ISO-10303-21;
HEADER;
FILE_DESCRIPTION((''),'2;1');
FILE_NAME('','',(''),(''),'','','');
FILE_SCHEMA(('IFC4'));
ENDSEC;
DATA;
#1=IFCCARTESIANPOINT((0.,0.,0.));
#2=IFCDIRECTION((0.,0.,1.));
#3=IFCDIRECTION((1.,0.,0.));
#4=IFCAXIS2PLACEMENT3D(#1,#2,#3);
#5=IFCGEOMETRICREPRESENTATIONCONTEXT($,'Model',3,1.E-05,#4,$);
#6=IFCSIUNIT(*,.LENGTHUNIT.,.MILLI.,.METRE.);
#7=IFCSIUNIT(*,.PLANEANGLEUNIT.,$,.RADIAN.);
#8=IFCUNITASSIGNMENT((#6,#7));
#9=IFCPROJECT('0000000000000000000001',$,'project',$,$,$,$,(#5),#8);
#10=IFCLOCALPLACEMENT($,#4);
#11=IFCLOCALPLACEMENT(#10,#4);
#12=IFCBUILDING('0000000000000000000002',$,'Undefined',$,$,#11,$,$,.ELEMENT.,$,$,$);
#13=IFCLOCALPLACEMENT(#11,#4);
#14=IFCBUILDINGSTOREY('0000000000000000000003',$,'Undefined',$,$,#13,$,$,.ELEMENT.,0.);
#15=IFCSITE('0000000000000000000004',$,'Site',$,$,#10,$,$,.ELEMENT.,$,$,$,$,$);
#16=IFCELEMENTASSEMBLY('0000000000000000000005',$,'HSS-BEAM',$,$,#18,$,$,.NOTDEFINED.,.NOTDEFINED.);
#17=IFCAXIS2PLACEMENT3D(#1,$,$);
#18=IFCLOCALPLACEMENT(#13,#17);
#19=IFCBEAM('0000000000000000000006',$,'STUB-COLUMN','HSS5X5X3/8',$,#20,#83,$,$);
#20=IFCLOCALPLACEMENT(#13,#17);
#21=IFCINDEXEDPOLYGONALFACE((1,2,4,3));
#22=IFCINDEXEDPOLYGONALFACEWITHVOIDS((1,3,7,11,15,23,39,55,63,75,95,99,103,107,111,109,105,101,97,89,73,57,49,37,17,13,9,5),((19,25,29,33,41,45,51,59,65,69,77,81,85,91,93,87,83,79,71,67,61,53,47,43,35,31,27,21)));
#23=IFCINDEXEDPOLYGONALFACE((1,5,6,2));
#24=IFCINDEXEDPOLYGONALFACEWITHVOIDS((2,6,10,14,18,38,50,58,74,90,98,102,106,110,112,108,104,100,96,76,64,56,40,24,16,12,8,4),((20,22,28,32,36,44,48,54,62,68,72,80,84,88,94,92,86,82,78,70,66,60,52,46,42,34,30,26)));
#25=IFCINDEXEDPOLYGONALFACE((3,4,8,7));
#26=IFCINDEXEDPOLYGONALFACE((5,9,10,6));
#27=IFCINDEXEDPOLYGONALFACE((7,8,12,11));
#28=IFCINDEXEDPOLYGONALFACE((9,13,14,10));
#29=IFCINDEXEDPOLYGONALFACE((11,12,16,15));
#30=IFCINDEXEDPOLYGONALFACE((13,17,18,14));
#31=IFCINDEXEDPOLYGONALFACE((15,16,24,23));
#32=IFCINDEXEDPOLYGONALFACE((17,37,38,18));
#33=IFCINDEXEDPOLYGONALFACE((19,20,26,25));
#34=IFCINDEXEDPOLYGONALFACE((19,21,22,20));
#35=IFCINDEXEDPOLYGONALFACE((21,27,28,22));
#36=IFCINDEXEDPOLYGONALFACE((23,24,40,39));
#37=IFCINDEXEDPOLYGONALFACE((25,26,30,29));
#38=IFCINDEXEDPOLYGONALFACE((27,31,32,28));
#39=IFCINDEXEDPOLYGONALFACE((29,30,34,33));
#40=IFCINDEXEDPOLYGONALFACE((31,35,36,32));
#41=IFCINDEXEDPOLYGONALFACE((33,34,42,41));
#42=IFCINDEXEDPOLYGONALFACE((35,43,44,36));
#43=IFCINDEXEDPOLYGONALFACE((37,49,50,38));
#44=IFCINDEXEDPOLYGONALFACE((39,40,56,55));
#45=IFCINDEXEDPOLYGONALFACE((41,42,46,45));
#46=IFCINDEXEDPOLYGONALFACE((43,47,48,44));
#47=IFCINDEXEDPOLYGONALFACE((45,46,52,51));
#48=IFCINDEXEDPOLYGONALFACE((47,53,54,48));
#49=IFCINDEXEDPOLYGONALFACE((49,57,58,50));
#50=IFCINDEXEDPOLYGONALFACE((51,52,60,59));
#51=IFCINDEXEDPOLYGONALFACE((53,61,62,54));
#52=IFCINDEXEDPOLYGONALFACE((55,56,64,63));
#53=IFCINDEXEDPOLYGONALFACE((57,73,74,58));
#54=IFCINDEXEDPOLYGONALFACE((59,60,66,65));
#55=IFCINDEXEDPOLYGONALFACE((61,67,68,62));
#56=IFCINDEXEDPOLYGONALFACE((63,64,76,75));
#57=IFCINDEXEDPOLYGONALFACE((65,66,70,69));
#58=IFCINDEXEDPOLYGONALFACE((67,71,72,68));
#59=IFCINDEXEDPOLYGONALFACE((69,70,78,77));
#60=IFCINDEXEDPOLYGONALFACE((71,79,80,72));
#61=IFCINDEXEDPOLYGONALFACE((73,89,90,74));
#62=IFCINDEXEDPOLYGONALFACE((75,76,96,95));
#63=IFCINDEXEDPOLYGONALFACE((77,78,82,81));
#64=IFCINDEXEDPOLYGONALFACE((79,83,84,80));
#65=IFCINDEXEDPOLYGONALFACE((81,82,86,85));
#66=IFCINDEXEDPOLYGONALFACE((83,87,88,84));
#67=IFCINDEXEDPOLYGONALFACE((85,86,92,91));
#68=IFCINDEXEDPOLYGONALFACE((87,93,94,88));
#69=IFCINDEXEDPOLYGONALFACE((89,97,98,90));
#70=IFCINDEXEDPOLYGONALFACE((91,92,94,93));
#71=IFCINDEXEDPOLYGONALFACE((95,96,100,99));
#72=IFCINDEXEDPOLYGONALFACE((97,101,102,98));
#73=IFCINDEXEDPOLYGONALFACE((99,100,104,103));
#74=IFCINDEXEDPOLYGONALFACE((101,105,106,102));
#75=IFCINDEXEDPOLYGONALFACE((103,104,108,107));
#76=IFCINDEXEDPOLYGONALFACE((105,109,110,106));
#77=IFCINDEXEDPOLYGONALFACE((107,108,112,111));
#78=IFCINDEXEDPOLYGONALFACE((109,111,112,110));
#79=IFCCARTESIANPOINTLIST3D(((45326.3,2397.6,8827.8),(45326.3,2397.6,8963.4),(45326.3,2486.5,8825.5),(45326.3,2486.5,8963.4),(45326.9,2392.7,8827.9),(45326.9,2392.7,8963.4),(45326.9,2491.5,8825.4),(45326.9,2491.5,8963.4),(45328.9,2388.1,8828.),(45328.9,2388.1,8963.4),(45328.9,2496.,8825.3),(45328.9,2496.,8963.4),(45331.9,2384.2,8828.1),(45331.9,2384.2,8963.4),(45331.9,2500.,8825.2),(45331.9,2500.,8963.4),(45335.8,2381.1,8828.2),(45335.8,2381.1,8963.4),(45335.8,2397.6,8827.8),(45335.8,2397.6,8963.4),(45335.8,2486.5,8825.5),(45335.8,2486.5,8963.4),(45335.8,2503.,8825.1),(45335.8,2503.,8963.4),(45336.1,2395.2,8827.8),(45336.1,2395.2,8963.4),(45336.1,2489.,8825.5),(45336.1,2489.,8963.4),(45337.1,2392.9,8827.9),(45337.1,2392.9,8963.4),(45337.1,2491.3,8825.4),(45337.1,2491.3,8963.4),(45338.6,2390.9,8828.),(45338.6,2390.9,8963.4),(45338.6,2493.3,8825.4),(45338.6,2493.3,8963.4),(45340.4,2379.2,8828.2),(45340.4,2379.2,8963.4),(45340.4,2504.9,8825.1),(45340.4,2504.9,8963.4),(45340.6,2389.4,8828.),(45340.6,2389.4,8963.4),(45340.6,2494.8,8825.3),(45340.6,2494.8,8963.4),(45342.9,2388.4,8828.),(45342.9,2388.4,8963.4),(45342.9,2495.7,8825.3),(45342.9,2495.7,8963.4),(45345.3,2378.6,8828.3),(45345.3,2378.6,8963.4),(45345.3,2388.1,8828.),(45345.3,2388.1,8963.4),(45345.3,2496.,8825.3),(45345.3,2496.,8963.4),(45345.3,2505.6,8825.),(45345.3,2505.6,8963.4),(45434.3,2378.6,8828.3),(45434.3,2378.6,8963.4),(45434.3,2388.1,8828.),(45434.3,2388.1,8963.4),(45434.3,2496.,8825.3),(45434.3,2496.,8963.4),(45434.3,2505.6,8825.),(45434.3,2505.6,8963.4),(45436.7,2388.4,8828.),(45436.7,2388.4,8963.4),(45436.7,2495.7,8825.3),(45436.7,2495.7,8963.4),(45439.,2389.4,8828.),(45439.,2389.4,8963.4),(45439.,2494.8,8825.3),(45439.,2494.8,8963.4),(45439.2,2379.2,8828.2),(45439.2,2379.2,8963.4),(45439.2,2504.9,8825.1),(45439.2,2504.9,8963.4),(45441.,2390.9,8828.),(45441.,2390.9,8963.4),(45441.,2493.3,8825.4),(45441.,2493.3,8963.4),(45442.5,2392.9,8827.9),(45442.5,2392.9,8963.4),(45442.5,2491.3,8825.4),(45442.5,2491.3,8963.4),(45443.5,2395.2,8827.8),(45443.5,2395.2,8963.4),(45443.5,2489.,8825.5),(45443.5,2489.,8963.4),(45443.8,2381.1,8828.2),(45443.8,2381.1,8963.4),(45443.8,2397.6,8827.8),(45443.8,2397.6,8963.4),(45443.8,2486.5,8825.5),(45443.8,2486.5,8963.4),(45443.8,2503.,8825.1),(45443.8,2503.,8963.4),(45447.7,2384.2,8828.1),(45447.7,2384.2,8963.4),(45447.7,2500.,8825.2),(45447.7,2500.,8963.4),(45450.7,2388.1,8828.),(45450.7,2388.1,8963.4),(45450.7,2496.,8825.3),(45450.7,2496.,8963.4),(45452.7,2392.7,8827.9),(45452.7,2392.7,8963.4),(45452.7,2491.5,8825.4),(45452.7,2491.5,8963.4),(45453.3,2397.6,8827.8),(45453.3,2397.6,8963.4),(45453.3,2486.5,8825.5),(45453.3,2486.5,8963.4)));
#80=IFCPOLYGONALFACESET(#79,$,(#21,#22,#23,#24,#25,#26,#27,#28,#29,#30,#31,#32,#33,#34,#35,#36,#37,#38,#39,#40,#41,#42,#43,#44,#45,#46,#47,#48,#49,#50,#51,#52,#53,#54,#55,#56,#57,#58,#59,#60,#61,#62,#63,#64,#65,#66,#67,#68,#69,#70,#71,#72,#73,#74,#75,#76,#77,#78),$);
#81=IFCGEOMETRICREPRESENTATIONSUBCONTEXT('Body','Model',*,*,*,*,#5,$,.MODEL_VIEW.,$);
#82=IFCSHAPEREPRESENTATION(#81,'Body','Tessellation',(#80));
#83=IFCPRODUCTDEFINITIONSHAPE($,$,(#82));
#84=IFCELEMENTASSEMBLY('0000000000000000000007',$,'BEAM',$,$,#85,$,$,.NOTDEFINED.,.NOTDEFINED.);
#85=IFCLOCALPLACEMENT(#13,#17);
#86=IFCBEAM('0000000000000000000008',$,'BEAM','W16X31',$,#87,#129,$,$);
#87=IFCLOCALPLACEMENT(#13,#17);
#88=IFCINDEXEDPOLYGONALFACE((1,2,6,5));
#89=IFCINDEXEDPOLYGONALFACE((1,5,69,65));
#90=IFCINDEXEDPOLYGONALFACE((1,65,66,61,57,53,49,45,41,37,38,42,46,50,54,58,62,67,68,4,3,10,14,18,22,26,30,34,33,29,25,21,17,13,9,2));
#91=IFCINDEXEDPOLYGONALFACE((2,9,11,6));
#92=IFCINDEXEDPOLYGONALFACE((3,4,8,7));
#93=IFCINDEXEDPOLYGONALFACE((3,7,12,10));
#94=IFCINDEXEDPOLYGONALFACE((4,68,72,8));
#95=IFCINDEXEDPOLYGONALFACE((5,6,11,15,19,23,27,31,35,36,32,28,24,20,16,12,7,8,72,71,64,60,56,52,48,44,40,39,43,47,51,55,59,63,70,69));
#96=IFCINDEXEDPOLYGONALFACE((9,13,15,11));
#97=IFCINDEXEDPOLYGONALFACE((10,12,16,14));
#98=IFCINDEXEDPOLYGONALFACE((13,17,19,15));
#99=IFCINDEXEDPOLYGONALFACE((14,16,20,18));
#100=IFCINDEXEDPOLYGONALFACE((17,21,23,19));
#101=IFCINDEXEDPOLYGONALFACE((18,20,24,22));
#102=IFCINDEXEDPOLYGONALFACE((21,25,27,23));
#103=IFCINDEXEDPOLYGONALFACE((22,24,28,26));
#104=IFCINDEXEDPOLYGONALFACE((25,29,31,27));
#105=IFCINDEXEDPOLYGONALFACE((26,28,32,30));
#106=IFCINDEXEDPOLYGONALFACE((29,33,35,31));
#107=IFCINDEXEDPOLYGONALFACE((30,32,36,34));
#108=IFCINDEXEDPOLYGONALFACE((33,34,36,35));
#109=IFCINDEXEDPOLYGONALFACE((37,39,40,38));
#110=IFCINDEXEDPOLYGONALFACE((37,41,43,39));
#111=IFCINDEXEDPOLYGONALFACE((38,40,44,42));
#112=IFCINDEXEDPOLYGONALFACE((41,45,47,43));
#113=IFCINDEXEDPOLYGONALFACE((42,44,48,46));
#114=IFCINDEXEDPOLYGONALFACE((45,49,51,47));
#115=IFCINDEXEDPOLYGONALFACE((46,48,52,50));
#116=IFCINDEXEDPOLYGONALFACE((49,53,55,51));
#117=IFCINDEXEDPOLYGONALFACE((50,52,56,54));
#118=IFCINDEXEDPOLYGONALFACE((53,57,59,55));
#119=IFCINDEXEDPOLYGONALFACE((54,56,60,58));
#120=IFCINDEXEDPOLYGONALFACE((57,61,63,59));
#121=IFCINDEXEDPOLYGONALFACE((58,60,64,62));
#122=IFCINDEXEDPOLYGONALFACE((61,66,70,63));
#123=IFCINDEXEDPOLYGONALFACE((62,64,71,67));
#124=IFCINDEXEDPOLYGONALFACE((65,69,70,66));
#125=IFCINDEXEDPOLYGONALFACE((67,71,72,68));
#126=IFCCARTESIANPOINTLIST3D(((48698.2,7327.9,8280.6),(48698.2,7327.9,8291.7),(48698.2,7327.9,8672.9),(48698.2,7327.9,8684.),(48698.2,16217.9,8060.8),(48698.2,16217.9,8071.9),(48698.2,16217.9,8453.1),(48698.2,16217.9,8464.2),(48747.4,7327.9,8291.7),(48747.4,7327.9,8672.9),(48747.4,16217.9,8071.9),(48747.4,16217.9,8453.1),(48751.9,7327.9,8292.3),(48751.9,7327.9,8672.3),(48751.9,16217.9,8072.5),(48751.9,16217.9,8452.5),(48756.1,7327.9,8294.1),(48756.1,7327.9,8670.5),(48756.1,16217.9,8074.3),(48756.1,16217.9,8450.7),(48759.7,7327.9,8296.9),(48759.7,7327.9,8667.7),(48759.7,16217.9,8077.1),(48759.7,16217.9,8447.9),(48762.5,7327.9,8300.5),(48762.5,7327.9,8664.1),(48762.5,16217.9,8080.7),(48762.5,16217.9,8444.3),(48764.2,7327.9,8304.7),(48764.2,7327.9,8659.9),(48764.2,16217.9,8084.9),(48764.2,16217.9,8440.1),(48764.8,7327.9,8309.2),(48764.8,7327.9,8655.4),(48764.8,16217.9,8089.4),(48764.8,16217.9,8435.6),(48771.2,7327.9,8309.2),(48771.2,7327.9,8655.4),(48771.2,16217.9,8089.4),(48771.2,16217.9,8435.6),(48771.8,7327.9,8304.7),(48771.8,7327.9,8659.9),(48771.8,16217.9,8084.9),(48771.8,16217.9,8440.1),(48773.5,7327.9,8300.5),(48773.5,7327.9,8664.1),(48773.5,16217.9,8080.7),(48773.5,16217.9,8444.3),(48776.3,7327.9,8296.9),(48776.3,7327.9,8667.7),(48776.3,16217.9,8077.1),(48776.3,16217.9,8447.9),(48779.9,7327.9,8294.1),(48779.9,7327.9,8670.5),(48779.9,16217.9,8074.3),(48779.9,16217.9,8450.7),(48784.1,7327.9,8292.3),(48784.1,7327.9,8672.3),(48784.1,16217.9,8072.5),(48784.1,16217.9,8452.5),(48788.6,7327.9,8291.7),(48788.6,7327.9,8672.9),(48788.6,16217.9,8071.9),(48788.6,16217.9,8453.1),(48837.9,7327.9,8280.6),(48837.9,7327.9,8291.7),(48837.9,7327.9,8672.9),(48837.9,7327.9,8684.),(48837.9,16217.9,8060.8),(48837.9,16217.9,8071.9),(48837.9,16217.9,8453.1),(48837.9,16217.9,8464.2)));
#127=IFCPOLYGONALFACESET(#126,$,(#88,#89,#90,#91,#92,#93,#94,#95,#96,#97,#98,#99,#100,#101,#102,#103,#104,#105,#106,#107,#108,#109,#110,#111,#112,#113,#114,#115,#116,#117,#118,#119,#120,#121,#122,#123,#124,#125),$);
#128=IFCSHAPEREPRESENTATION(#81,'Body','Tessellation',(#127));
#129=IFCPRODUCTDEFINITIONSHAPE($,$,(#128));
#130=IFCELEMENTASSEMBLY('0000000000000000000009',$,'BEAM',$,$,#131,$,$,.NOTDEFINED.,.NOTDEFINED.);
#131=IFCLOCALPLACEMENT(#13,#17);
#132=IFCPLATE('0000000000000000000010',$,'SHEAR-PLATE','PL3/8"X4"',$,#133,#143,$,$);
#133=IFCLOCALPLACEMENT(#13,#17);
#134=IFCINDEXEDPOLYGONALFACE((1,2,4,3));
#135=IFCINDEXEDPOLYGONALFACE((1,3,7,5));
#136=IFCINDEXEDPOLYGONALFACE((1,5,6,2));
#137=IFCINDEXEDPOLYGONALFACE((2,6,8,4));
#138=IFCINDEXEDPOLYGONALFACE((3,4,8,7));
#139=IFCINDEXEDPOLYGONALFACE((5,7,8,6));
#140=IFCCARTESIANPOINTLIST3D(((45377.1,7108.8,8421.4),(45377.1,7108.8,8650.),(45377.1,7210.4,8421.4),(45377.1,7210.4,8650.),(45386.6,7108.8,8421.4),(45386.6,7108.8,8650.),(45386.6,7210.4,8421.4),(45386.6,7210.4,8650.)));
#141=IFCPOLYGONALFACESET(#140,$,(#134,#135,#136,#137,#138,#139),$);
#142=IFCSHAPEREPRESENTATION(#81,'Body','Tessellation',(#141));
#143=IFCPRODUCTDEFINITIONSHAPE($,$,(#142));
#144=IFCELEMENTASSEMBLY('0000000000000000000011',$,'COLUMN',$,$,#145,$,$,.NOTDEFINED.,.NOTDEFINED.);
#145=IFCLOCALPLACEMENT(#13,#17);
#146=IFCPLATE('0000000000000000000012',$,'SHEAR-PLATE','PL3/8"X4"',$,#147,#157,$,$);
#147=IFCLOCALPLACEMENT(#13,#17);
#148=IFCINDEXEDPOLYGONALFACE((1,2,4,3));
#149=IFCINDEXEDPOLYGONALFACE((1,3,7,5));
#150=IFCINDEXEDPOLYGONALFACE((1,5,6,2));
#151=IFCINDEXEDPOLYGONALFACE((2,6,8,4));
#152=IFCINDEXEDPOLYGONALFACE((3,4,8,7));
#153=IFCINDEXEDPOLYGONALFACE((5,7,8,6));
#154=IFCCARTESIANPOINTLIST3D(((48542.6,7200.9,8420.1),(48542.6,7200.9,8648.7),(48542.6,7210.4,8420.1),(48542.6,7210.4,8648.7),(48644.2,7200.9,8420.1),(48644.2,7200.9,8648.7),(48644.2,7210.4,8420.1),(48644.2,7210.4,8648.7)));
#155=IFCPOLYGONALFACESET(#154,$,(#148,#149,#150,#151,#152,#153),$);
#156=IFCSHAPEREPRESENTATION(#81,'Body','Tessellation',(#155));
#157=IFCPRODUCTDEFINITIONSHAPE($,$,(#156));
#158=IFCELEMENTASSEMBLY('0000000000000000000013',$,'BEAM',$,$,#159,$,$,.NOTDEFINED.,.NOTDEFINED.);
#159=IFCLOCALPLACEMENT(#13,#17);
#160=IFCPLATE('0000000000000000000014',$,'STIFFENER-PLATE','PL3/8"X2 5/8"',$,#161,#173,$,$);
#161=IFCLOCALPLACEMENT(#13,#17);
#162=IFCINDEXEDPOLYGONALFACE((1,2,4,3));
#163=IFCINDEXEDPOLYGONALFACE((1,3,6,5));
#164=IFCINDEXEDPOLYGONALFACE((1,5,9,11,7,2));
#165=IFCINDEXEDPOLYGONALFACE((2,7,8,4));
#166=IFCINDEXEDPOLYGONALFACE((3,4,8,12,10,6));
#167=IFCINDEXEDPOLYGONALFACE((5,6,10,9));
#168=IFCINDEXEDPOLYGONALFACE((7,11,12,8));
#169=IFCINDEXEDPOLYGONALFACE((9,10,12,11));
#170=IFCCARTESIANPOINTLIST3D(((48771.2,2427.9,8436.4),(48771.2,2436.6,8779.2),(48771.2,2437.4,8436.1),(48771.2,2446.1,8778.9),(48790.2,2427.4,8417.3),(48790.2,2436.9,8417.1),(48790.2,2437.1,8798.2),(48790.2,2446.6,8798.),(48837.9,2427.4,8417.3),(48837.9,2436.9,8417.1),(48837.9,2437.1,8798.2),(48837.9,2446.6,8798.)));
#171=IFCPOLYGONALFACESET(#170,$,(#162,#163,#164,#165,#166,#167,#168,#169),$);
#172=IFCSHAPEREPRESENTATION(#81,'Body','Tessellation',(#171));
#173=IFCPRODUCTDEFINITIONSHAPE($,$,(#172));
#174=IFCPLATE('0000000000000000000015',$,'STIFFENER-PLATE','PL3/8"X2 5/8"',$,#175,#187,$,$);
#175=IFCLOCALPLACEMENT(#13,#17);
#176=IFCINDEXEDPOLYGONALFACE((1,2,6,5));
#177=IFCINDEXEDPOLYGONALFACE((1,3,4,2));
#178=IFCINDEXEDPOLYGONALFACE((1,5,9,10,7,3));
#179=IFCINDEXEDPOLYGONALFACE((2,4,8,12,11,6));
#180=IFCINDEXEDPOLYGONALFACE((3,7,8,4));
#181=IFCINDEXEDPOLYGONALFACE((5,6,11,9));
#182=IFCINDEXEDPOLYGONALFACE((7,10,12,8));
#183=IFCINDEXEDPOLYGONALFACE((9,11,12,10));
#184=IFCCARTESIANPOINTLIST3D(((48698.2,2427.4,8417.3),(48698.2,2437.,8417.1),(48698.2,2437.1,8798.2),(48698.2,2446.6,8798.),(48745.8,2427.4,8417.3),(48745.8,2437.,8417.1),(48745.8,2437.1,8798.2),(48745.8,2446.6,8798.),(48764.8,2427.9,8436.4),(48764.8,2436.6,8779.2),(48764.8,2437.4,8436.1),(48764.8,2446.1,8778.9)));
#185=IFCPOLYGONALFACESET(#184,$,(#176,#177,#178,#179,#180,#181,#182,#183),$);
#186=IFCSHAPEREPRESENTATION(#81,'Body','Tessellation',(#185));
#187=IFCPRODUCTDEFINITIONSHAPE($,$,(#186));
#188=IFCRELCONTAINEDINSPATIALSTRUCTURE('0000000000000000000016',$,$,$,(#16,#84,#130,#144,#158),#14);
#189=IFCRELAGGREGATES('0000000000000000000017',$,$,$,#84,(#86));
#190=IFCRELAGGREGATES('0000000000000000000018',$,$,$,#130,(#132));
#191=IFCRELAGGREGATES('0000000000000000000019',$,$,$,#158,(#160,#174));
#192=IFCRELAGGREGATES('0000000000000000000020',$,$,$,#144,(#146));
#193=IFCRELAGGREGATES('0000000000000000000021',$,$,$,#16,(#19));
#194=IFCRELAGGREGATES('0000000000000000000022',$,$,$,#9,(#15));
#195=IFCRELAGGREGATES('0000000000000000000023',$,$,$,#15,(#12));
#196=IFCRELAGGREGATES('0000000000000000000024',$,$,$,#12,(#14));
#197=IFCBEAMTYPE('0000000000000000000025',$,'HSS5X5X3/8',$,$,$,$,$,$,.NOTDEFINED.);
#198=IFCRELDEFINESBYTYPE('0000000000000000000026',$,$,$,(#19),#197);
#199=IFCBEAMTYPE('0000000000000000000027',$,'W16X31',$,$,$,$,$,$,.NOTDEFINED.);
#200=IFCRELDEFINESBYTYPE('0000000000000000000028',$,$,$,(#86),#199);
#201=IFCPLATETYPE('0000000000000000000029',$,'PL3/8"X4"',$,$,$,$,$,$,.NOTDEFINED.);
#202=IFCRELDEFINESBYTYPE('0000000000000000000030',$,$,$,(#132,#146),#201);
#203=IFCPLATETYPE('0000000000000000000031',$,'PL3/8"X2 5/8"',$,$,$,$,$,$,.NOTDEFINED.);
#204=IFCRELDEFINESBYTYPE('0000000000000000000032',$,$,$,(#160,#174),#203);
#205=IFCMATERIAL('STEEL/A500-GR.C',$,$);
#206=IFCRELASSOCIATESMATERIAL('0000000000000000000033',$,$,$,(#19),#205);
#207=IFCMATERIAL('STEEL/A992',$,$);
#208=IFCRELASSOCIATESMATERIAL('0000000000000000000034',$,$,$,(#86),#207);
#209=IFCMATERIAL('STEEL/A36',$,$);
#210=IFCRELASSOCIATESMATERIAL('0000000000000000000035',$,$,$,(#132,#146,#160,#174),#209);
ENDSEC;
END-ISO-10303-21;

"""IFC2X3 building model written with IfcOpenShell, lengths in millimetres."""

from ifc_helpers import new_model, si_unit, frame, origin_with_axes, origin_2d_with_axis, place, context, subcontext, project, spatial, polyline, rectangle, hollow_rectangle, i_section, outline, extrude, boolean, clip, halfspace, material, type_object, element, aggregate, save


model = new_model("IFC2X3")

# Units and contexts
model_context = context("Model", 3, precision=1e-05, world=origin_with_axes())
body_context = subcontext(model_context, "Body", "Model", "MODEL_VIEW")
ifc_project = project(units=[si_unit("LENGTHUNIT", "METRE", prefix="MILLI"), si_unit("PLANEANGLEUNIT", "RADIAN")], contexts=[model_context])

# Site, building, storey
site_placement = place(None, origin_with_axes())
site = spatial("IfcSite", under=ifc_project, at=site_placement, Name="Site", CompositionType="ELEMENT")
building_placement = place(site_placement, origin_with_axes())
building = spatial("IfcBuilding", under=site, at=building_placement, Name="Undefined", CompositionType="ELEMENT")
storey_placement = place(building_placement, origin_with_axes())
storey = spatial("IfcBuildingStorey", under=building, at=storey_placement, Name="Undefined", CompositionType="ELEMENT", Elevation=0.0)

# Shared definitions
ifc_material_1 = material(Name="STEEL/A36")

# Shared definitions
ifc_material_2 = material(Name="STEEL/A992")

# Element assembly, beam
assembly_1_placement = place(storey_placement, origin_with_axes())
assembly_1 = element("IfcElementAssembly", 1, at=assembly_1_placement, inside=storey, Name="HSS-BEAM", AssemblyPlace="NOTDEFINED", PredefinedType="NOTDEFINED")
ifc_material_3 = material(Name="STEEL/A500-GR.C")
beam_type_1 = type_object("IfcBeamType", Name="HSS5X5X3/8", PredefinedType="NOTDEFINED")
beam_1_placement = place(assembly_1_placement, frame((45389.8, 2442.1, 8963.4), z_axis=(1.0, 0.0, 0.0), x_axis=(0.0, 0.0, -1.0)))
beam_1 = element("IfcBeam", 2, at=beam_1_placement, type_object=beam_type_1, material=ifc_material_3, Name="STUB-COLUMN", Description="HSS5X5X3/8", context=body_context, shape_type="Clipping", body=[
    clip(clip(extrude(hollow_rectangle(XDim=127.0, YDim=127.0, WallThickness=9.5, InnerFilletRadius=9.5, OuterFilletRadius=19.0, at=origin_2d_with_axis()), frame((155.8, 0.0, 0.0), z_axis=(-1.0, 0.0, 0.0), x_axis=(0.0, -1.0, 0.0)), (0.0, 0.0, 1.0), 157.4), halfspace(frame((136.7, 0.0, -63.5), z_axis=(-0.99968, 0.025308, 0.0), x_axis=(0.025308, 0.99968, 0.0)), True)), halfspace(frame((0.0, 0.0, -1000.0), z_axis=(1.0, 0.0, 0.0), x_axis=(0.0, -1.0, 0.0)), True)),
])

# Element assembly, beam
beam_type_2 = type_object("IfcBeamType", Name="W16X31", PredefinedType="NOTDEFINED")
assembly_2_placement = place(storey_placement, origin_with_axes())
assembly_2 = element("IfcElementAssembly", 3, at=assembly_2_placement, inside=storey, Name="BEAM", AssemblyPlace="NOTDEFINED", PredefinedType="NOTDEFINED")
beam_2_placement = place(assembly_2_placement, frame((48768.0, 7208.6, 8485.2), z_axis=(0.0, 0.024718, 0.999694), x_axis=(0.0, 0.999694, -0.024718)))
beam_2 = element("IfcBeam", 4, at=beam_2_placement, type_object=beam_type_2, material=ifc_material_2, Name="BEAM", Description="W16X31", context=body_context, shape_type="CSG", body=[
    boolean("DIFFERENCE", boolean("DIFFERENCE", boolean("DIFFERENCE", extrude(i_section(OverallWidth=139.7, OverallDepth=403.2, WebThickness=6.3, FlangeThickness=11.1, FilletRadius=17.5, at=origin_2d_with_axis()), frame((9248.4, 0.0, 0.0), z_axis=(-1.0, 0.0, 0.0), x_axis=(0.0, -1.0, 0.0)), (0.0, 0.0, 1.0), 9248.4), extrude(rectangle(XDim=281.8, YDim=281.8, at=origin_2d_with_axis()), frame((145.9, 144.7, 161.8), z_axis=(0.024718, 0.0, -0.999694), x_axis=(0.999694, 0.0, 0.024718)), (0.0, 0.0, 1.0), 230.6)), halfspace(frame((8999.1, 0.0, 521.3), z_axis=(0.999694, 0.0, 0.024718), x_axis=(0.0, 1.0, 0.0)), False)), halfspace(frame((111.8, 0.0, 304.4), z_axis=(-0.999694, 0.0, -0.024718), x_axis=(0.0, -1.0, 0.0)), False)),
])
aggregate(assembly_2, [beam_2])

# Element assemblies, plates
assembly_3_placement = place(storey_placement, origin_with_axes())
assembly_3 = element("IfcElementAssembly", 5, at=assembly_3_placement, inside=storey, Name="BEAM", AssemblyPlace="NOTDEFINED", PredefinedType="NOTDEFINED")
plate_type_1 = type_object("IfcPlateType", Name="PL3/8\"X4\"", PredefinedType="NOTDEFINED")
plate_1_placement = place(assembly_3_placement, frame((45381.9, 7210.4, 8650.0), z_axis=(-1.0, 0.0, 0.0), x_axis=(0.0, 0.0, -1.0)))
plate_1 = element("IfcPlate", 6, at=plate_1_placement, type_object=plate_type_1, material=ifc_material_1, Name="SHEAR-PLATE", Description="PL3/8\"X4\"", context=body_context, shape_type="SweptSolid", body=[
    extrude(outline(polyline([(0.0, 0.0), (228.6, 0.0), (228.6, 101.6), (0.0, 101.6), (0.0, 0.0)])), frame((0.0, 0.0, -4.8), z_axis=(0.0, 0.0, 1.0), x_axis=(1.0, 0.0, 0.0)), (0.0, 0.0, 1.0), 9.5),
])
aggregate(assembly_3, [plate_1])
assembly_4_placement = place(storey_placement, origin_with_axes())
assembly_4 = element("IfcElementAssembly", 7, at=assembly_4_placement, inside=storey, Name="COLUMN", AssemblyPlace="NOTDEFINED", PredefinedType="NOTDEFINED")
plate_2_placement = place(assembly_4_placement, frame((48644.2, 7205.7, 8648.7), z_axis=(0.0, 1.0, 0.0), x_axis=(0.0, 0.0, -1.0)))
plate_2 = element("IfcPlate", 8, at=plate_2_placement, type_object=plate_type_1, material=ifc_material_1, Name="SHEAR-PLATE", Description="PL3/8\"X4\"", context=body_context, shape_type="SweptSolid", body=[
    extrude(outline(polyline([(0.0, 0.0), (228.6, 0.0), (228.6, 101.6), (0.0, 101.6), (0.0, 0.0)])), frame((0.0, 0.0, -4.8), z_axis=(0.0, 0.0, 1.0), x_axis=(1.0, 0.0, 0.0)), (0.0, 0.0, 1.0), 9.5),
])

# Element assembly, plates
assembly_5_placement = place(storey_placement, origin_with_axes())
assembly_5 = element("IfcElementAssembly", 9, at=assembly_5_placement, inside=storey, Name="BEAM", AssemblyPlace="NOTDEFINED", PredefinedType="NOTDEFINED")
plate_type_2 = type_object("IfcPlateType", Name="PL3/8\"X2 5/8\"", PredefinedType="NOTDEFINED")
plate_3_placement = place(assembly_5_placement, frame((48837.9, 2441.8, 8798.1), z_axis=(0.0, -0.99968, 0.025308), x_axis=(-1.0, 0.0, 0.0)))
plate_3 = element("IfcPlate", 10, at=plate_3_placement, type_object=plate_type_2, material=ifc_material_1, Name="STIFFENER-PLATE", Description="PL3/8\"X2 5/8\"", context=body_context, shape_type="SweptSolid", body=[
    extrude(outline(polyline([(0.0, 0.0), (47.6, 0.0), (66.7, 19.0), (66.7, 362.0), (47.6, 381.0), (0.0, 381.0), (0.0, 0.0)])), frame((0.0, 0.0, -4.8), z_axis=(0.0, 0.0, 1.0), x_axis=(1.0, 0.0, 0.0)), (0.0, 0.0, 1.0), 9.5),
])
plate_4_placement = place(assembly_5_placement, frame((48698.2, 2441.8, 8798.1), z_axis=(0.0, 0.99968, -0.025308), x_axis=(1.0, 0.0, 0.0)))
plate_4 = element("IfcPlate", 11, at=plate_4_placement, type_object=plate_type_2, material=ifc_material_1, Name="STIFFENER-PLATE", Description="PL3/8\"X2 5/8\"", context=body_context, shape_type="SweptSolid", body=[
    extrude(outline(polyline([(0.0, 0.0), (47.6, 0.0), (66.7, 19.0), (66.7, 362.0), (47.6, 381.0), (0.0, 381.0), (0.0, 0.0)])), frame((0.0, 0.0, -4.8), z_axis=(0.0, 0.0, 1.0), x_axis=(1.0, 0.0, 0.0)), (0.0, 0.0, 1.0), 9.5),
])
aggregate(assembly_5, [plate_3, plate_4])

aggregate(assembly_4, [plate_2])
aggregate(assembly_1, [beam_1])

save(model, "model.ifc")
